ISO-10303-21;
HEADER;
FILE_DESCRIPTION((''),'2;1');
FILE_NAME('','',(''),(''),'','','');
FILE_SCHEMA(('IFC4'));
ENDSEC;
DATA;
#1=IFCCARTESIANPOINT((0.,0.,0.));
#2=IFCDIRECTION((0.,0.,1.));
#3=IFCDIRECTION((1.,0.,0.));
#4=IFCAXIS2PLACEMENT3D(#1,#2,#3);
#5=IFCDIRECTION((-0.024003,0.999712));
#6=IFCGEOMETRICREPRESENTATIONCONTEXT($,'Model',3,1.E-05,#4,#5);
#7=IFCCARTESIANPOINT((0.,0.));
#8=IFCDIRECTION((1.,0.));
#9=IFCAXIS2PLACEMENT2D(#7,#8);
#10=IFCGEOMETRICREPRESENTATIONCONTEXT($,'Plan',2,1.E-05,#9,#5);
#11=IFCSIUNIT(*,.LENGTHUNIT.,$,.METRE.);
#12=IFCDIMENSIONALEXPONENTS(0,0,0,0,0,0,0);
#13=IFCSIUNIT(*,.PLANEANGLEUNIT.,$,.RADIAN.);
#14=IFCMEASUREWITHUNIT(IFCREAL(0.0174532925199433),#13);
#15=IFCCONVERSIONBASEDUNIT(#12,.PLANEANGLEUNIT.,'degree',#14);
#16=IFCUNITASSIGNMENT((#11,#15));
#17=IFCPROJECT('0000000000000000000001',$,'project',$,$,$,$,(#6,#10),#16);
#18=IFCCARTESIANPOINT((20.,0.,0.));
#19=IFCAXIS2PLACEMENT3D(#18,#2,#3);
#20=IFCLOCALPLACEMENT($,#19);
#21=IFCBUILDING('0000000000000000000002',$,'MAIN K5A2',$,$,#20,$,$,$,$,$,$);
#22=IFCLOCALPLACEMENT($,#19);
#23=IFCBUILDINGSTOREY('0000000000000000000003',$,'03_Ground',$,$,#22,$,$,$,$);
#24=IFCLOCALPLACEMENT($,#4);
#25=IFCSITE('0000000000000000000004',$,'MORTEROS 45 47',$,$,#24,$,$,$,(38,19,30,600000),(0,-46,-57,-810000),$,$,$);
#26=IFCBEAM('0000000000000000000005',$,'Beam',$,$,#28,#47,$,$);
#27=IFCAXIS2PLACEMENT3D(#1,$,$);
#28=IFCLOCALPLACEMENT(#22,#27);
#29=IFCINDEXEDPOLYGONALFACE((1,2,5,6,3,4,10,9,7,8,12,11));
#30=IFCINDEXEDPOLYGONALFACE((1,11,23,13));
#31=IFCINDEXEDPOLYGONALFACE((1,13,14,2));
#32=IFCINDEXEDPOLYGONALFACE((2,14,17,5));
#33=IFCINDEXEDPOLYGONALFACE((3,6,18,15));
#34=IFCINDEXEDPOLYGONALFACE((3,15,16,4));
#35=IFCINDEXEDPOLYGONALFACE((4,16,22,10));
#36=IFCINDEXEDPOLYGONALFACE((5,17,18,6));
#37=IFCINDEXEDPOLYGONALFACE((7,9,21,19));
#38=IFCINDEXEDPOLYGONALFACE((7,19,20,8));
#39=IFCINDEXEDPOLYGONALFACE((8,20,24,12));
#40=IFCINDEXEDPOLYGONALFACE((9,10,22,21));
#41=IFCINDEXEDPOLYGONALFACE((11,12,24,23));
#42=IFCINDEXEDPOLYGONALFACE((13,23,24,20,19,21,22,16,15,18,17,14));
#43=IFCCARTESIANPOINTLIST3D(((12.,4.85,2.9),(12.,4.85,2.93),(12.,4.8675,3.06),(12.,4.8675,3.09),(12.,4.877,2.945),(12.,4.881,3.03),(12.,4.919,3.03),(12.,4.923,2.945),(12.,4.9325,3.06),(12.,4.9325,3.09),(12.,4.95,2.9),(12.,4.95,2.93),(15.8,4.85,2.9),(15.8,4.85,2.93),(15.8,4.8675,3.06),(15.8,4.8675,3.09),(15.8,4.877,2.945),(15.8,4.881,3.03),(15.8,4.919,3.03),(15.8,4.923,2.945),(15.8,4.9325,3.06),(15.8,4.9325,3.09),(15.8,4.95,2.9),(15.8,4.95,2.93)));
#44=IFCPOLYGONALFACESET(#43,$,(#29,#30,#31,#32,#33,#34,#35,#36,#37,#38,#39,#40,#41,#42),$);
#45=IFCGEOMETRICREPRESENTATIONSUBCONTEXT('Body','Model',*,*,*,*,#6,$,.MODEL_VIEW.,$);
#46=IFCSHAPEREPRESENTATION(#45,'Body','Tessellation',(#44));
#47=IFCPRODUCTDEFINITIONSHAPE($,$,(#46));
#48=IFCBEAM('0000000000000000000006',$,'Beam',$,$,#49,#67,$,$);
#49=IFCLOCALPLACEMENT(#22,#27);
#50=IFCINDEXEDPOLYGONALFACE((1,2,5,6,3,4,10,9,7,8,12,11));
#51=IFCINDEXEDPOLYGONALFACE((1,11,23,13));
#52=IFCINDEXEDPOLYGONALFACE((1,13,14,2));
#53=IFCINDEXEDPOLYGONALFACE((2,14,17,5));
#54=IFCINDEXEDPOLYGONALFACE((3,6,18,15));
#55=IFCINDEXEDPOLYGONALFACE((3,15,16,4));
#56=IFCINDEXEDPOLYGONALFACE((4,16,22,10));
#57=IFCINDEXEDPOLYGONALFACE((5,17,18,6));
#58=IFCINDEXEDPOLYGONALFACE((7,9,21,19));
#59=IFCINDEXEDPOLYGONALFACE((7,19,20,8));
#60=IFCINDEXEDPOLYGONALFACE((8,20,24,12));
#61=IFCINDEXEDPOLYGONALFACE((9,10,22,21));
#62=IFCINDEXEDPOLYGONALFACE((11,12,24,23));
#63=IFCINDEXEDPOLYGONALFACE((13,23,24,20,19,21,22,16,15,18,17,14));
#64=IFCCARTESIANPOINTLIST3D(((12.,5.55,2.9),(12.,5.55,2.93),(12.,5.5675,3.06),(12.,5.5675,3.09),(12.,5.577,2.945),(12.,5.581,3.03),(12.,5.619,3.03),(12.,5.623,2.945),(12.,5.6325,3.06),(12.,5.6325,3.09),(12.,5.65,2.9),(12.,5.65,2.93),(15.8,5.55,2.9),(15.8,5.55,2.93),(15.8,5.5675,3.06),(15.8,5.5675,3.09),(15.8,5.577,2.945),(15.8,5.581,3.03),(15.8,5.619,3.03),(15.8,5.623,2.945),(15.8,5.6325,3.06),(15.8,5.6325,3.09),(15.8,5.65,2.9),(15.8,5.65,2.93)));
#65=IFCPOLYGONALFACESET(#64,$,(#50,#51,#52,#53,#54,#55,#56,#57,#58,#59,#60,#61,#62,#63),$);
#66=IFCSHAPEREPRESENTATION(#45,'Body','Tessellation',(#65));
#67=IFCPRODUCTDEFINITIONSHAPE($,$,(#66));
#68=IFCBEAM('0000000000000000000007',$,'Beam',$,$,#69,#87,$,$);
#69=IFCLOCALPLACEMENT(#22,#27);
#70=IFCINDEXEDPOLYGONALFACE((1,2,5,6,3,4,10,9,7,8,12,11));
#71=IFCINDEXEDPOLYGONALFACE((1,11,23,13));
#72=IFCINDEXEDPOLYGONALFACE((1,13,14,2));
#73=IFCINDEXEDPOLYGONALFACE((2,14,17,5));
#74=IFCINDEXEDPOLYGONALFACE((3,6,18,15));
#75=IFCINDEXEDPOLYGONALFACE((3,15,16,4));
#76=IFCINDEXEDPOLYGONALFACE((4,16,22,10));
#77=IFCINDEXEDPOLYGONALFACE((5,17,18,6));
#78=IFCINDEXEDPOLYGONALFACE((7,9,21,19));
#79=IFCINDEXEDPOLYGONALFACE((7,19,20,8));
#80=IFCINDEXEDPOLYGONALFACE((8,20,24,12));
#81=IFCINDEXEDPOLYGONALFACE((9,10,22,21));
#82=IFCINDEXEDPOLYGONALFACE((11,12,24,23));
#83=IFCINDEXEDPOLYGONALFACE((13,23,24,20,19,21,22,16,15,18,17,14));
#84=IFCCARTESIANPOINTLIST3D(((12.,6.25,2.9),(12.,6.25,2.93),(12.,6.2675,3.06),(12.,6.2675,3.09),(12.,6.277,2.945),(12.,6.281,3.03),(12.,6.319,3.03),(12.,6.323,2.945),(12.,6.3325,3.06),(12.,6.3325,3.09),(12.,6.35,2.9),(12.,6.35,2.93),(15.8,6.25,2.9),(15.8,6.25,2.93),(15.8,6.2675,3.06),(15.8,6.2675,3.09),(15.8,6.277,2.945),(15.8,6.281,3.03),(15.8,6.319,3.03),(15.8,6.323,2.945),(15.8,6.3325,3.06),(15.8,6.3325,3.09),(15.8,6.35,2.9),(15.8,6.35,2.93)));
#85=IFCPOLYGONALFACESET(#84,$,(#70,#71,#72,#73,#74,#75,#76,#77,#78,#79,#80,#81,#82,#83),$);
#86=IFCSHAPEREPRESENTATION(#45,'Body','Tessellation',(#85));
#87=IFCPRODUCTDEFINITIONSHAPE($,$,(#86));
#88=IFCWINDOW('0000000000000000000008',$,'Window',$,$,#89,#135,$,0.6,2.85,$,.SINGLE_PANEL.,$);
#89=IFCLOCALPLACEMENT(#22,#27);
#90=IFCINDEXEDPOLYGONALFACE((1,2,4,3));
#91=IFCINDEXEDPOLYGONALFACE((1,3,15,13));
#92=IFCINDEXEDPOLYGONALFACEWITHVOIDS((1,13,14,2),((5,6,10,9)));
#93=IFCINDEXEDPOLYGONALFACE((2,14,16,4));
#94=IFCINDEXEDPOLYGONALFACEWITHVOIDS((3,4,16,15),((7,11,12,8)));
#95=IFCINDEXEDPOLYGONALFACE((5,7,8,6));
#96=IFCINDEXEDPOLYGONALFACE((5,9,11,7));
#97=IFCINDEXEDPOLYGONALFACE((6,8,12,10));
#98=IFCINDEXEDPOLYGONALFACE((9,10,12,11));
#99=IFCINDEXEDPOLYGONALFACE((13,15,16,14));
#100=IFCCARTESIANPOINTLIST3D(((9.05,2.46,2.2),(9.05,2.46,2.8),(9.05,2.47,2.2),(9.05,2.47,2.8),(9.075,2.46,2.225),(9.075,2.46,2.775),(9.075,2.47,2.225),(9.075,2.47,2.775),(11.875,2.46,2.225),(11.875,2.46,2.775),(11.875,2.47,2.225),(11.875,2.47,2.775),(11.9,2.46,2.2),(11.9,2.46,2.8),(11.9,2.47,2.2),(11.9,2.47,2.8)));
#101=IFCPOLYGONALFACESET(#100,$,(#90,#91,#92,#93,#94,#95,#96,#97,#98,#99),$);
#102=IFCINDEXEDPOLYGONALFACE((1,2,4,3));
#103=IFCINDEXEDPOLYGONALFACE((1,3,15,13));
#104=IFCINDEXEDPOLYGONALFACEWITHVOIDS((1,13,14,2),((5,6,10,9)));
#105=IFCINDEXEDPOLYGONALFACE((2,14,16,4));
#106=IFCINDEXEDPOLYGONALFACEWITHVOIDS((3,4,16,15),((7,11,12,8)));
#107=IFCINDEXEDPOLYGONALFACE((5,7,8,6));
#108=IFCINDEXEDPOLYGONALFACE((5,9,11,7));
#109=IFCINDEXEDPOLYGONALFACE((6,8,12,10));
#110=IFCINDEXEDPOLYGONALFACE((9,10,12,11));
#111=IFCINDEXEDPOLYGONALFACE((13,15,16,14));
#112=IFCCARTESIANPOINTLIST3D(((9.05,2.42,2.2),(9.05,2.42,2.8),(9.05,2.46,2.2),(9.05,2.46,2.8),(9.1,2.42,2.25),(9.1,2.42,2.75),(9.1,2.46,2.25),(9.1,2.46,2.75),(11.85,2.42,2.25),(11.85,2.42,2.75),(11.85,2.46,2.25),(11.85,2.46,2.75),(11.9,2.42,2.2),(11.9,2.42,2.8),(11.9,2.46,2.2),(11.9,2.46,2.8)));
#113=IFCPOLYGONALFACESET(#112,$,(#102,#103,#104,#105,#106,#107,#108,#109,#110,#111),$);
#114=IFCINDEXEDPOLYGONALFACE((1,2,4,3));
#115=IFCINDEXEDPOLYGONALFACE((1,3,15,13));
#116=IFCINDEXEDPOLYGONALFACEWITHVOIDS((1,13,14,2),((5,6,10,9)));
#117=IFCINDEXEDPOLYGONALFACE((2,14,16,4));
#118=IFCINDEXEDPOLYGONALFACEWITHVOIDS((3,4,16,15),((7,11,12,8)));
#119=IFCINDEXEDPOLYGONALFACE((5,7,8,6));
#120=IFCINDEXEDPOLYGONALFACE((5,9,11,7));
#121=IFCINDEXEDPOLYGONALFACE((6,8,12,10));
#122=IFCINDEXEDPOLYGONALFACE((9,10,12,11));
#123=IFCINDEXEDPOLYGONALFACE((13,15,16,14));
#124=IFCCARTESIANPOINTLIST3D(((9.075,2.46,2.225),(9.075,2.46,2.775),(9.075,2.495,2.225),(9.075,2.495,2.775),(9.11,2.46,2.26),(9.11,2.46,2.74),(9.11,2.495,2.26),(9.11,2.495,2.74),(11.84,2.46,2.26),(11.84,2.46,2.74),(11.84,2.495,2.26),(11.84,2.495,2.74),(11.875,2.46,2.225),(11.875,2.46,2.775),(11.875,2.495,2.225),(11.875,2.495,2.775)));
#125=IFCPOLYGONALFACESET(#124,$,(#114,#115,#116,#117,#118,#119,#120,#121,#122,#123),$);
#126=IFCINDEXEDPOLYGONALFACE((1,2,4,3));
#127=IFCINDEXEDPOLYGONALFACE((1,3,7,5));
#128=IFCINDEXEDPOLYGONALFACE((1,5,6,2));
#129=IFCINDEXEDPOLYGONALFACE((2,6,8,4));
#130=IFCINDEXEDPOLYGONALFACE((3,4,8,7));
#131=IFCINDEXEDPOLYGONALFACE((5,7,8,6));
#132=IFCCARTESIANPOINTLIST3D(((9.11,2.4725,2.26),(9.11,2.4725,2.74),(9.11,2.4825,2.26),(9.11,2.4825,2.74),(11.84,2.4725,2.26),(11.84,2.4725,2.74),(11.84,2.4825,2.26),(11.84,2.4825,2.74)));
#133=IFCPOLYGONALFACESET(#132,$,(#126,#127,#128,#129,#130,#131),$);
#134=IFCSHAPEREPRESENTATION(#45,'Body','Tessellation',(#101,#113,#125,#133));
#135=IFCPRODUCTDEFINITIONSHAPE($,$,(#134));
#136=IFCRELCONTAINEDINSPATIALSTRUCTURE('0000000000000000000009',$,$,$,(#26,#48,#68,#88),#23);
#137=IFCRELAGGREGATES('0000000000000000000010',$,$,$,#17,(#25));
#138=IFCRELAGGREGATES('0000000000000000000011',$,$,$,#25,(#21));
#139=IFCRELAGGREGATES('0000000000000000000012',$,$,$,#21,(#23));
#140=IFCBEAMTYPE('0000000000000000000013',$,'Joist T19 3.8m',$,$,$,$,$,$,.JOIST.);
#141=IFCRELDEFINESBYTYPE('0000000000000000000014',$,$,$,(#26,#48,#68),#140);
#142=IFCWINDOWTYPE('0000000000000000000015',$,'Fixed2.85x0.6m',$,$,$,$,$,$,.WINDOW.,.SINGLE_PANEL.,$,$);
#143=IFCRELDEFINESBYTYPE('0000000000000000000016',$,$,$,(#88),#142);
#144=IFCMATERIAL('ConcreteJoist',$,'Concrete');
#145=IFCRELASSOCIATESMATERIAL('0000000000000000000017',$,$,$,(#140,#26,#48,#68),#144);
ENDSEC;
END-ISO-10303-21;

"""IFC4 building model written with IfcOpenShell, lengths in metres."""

from ifc_helpers import new_model, entity, si_unit, converted_unit, direction, frame, origin_with_axes, origin_2d_with_axis, place, context, subcontext, project, spatial, line, indexed_curve, outline, extrude, shape, source, transform, mapped, material, material_profile, profile_set, profile_usage, type_object, element, save


model = new_model("IFC4")

# Units and contexts
model_context = context("Model", 3, precision=1e-05, world=origin_with_axes(), true_north=direction((-0.024003, 0.999712)))
plan_context = context("Plan", 2, precision=1e-05, world=origin_2d_with_axis(), true_north=direction((-0.024003, 0.999712)))
body_context_1 = subcontext(model_context, "Body", "Model", "MODEL_VIEW")
body_context_2 = subcontext(plan_context, "Body", "Plan", "PLAN_VIEW")
ifc_project = project(units=[si_unit("LENGTHUNIT", "METRE"), converted_unit("PLANEANGLEUNIT", "degree", entity("IfcReal", 0.0174532925199433), si_unit("PLANEANGLEUNIT", "RADIAN"), dimensions=[0, 0, 0, 0, 0, 0, 0])], contexts=[model_context, plan_context])

# Site, building, storey
site_placement = place(None, origin_with_axes())
site = spatial("IfcSite", under=ifc_project, at=site_placement, Name="MORTEROS 45 47", RefLatitude=(38, 19, 30, 600000), RefLongitude=(0, -46, -57, -810000))
building_placement = place(None, frame((20.0, 0.0, 0.0), z_axis=(0.0, 0.0, 1.0), x_axis=(1.0, 0.0, 0.0)))
building = spatial("IfcBuilding", under=site, at=building_placement, Name="MAIN K5A2")
storey_placement = place(None, frame((20.0, 0.0, 0.0), z_axis=(0.0, 0.0, 1.0), x_axis=(1.0, 0.0, 0.0)))
storey = spatial("IfcBuildingStorey", under=building, at=storey_placement, Name="03_Ground")

# Beams
ifc_material = material(Name="ConcreteJoist", Category="Concrete")
ifc_material_profile_1 = material_profile(ifc_material, outline(indexed_curve([(0.019, 0.13), (0.023, 0.045), (0.05, 0.03), (0.05, 0.0), (-0.05, 0.0), (-0.05, 0.03), (-0.023, 0.045), (-0.019, 0.13), (-0.0325, 0.16), (-0.0325, 0.19), (0.0325, 0.19), (0.0325, 0.16), (0.019, 0.13)])))
ifc_profile_set_1 = profile_set([ifc_material_profile_1], Name="JoistMaterialProfileSet")
ifc_material_profile_2 = material_profile(ifc_material, outline(indexed_curve([(0.019, 0.13), (0.023, 0.045), (0.05, 0.03), (0.05, 0.0), (-0.05, 0.0), (-0.05, 0.03), (-0.023, 0.045), (-0.019, 0.13), (-0.0325, 0.16), (-0.0325, 0.19), (0.0325, 0.19), (0.0325, 0.16), (0.019, 0.13)])))
ifc_profile_set_2 = profile_set([ifc_material_profile_2], Name="JoistMaterialProfileSet")
beam_type_1 = type_object("IfcBeamType", Name="Joist T19 3.8m", PredefinedType="JOIST", material=ifc_profile_set_2)
ifc_profile_usage_1 = profile_usage(ifc_profile_set_1)
beam_1_placement = place(None, frame((32.0, 4.9, 2.9), z_axis=(1.0, 0.0, 0.0), x_axis=(0.0, 1.0, 0.0)))
element("IfcBeam", 1, at=beam_1_placement, inside=storey, type_object=beam_type_1, material=ifc_profile_usage_1, Name="Beam", context=body_context_1, shape_type="SweptSolid", body=[
    extrude(outline(indexed_curve([(0.019, 0.13), (0.023, 0.045), (0.05, 0.03), (0.05, 0.0), (-0.05, 0.0), (-0.05, 0.03), (-0.023, 0.045), (-0.019, 0.13), (-0.0325, 0.16), (-0.0325, 0.19), (0.0325, 0.19), (0.0325, 0.16), (0.019, 0.13)])), origin_with_axes(), (0.0, 0.0, 1.0), 3.8),
])
ifc_profile_usage_2 = profile_usage(ifc_profile_set_1)
beam_2_placement = place(None, frame((32.0, 5.6, 2.9), z_axis=(1.0, 0.0, 0.0), x_axis=(0.0, 1.0, 0.0)))
element("IfcBeam", 2, at=beam_2_placement, inside=storey, type_object=beam_type_1, material=ifc_profile_usage_2, Name="Beam", context=body_context_1, shape_type="SweptSolid", body=[
    extrude(outline(indexed_curve([(0.019, 0.13), (0.023, 0.045), (0.05, 0.03), (0.05, 0.0), (-0.05, 0.0), (-0.05, 0.03), (-0.023, 0.045), (-0.019, 0.13), (-0.0325, 0.16), (-0.0325, 0.19), (0.0325, 0.19), (0.0325, 0.16), (0.019, 0.13)])), origin_with_axes(), (0.0, 0.0, 1.0), 3.8),
])
ifc_profile_usage_3 = profile_usage(ifc_profile_set_1)
beam_3_placement = place(None, frame((32.0, 6.3, 2.9), z_axis=(1.0, 0.0, 0.0), x_axis=(0.0, 1.0, 0.0)))
element("IfcBeam", 3, at=beam_3_placement, inside=storey, type_object=beam_type_1, material=ifc_profile_usage_3, Name="Beam", context=body_context_1, shape_type="SweptSolid", body=[
    extrude(outline(indexed_curve([(0.019, 0.13), (0.023, 0.045), (0.05, 0.03), (0.05, 0.0), (-0.05, 0.0), (-0.05, 0.03), (-0.023, 0.045), (-0.019, 0.13), (-0.0325, 0.16), (-0.0325, 0.19), (0.0325, 0.19), (0.0325, 0.16), (0.019, 0.13)])), origin_with_axes(), (0.0, 0.0, 1.0), 3.8),
])

# Window
window_type_1 = type_object("IfcWindowType", Name="Fixed2.85x0.6m", PartitioningType="SINGLE_PANEL", PredefinedType="WINDOW")
shared_shape_1 = source(origin_with_axes(), body_context_1, "Body", "SolidModel", [
    extrude(outline(indexed_curve([(0.0, 0.0), (2.85, 0.0), (2.85, 0.6), (0.0, 0.6)], segments=[line(1, 2, 3, 4, 1)]), holes=[indexed_curve([(0.025, 0.025), (2.825, 0.025), (2.825, 0.575), (0.025, 0.575)], segments=[line(1, 2, 3, 4, 1)])]), frame((0.0, 0.09, 0.0), z_axis=(0.0, -1.0, 0.0), x_axis=(1.0, 0.0, 0.0)), (0.0, 0.0, -1.0), 0.01),
    extrude(outline(indexed_curve([(0.0, 0.0), (2.85, 0.0), (2.85, 0.6), (0.0, 0.6)], segments=[line(1, 2, 3, 4, 1)]), holes=[indexed_curve([(0.05, 0.05), (2.8, 0.05), (2.8, 0.55), (0.05, 0.55)], segments=[line(1, 2, 3, 4, 1)])]), frame((0.0, 0.05, 0.0), z_axis=(0.0, -1.0, 0.0), x_axis=(1.0, 0.0, 0.0)), (0.0, 0.0, -1.0), 0.04),
    extrude(outline(indexed_curve([(0.0, 0.0), (2.8, 0.0), (2.8, 0.55), (0.0, 0.55)], segments=[line(1, 2, 3, 4, 1)]), holes=[indexed_curve([(0.035, 0.035), (2.765, 0.035), (2.765, 0.515), (0.035, 0.515)], segments=[line(1, 2, 3, 4, 1)])]), frame((0.025, 0.09, 0.025), z_axis=(0.0, -1.0, 0.0), x_axis=(1.0, 0.0, 0.0)), (0.0, 0.0, -1.0), 0.035),
    extrude(outline(indexed_curve([(0.035, 0.035), (2.765, 0.035), (2.765, 0.515), (0.035, 0.515)], segments=[line(1, 2, 3, 4, 1)])), frame((0.025, 0.1025, 0.025), z_axis=(0.0, -1.0, 0.0), x_axis=(1.0, 0.0, 0.0)), (0.0, 0.0, -1.0), 0.01),
])
shared_shape_2 = source(origin_with_axes(), body_context_2, "Body", "Curve2D", [
    entity("IfcIndexedPolyCurve", entity("IfcCartesianPointList2D", [[0.05, 0.05], [2.8, 0.05]])),
    entity("IfcIndexedPolyCurve", entity("IfcCartesianPointList2D", [[0.0, 0.1], [0.025, 0.1], [0.025, 0.09], [0.05, 0.09], [0.05, 0.05], [0.0, 0.05]]), [entity("IfcLineIndex", [1, 2, 3, 4, 5, 6, 1])]),
    entity("IfcIndexedPolyCurve", entity("IfcCartesianPointList2D", [[2.85, 0.1], [2.825, 0.1], [2.825, 0.09], [2.8, 0.09], [2.8, 0.05], [2.85, 0.05]]), [entity("IfcLineIndex", [1, 2, 3, 4, 5, 6, 1])]),
    entity("IfcIndexedPolyCurve", entity("IfcCartesianPointList2D", [[0.025, 0.09], [0.06, 0.09], [0.06, 0.125], [0.025, 0.125]]), [entity("IfcLineIndex", [1, 2, 3, 4, 1])]),
    entity("IfcIndexedPolyCurve", entity("IfcCartesianPointList2D", [[2.825, 0.09], [2.79, 0.09], [2.79, 0.125], [2.825, 0.125]]), [entity("IfcLineIndex", [1, 2, 3, 4, 1])]),
    entity("IfcIndexedPolyCurve", entity("IfcCartesianPointList2D", [[0.06, 0.09], [2.79, 0.09]])),
    entity("IfcIndexedPolyCurve", entity("IfcCartesianPointList2D", [[0.06, 0.125], [2.79, 0.125]])),
    entity("IfcIndexedPolyCurve", entity("IfcCartesianPointList2D", [[0.06, 0.1075], [2.79, 0.1075]])),
])
window_placement = place(None, frame((29.05, 2.37, 2.2), z_axis=(0.0, 0.0, 1.0), x_axis=(1.0, 0.0, 0.0)))
element("IfcWindow", 4, at=window_placement, inside=storey, type_object=window_type_1, Name="Window", OverallHeight=0.6, OverallWidth=2.85, PartitioningType="SINGLE_PANEL", shapes=[
    shape(body_context_1, "Body", "MappedRepresentation", [mapped(shared_shape_1, transform((0.0, 0.0, 0.0), x_axis=(1.0, 0.0, 0.0), y_axis=(0.0, 1.0, 0.0), z_axis=(0.0, 0.0, 1.0), scale=1.0))]),
    shape(body_context_2, "Body", "MappedRepresentation", [mapped(shared_shape_2, transform((0.0, 0.0, 0.0), x_axis=(1.0, 0.0, 0.0), y_axis=(0.0, 1.0, 0.0), z_axis=(0.0, 0.0, 1.0), scale=1.0))]),
])

save(model, "model.ifc")
